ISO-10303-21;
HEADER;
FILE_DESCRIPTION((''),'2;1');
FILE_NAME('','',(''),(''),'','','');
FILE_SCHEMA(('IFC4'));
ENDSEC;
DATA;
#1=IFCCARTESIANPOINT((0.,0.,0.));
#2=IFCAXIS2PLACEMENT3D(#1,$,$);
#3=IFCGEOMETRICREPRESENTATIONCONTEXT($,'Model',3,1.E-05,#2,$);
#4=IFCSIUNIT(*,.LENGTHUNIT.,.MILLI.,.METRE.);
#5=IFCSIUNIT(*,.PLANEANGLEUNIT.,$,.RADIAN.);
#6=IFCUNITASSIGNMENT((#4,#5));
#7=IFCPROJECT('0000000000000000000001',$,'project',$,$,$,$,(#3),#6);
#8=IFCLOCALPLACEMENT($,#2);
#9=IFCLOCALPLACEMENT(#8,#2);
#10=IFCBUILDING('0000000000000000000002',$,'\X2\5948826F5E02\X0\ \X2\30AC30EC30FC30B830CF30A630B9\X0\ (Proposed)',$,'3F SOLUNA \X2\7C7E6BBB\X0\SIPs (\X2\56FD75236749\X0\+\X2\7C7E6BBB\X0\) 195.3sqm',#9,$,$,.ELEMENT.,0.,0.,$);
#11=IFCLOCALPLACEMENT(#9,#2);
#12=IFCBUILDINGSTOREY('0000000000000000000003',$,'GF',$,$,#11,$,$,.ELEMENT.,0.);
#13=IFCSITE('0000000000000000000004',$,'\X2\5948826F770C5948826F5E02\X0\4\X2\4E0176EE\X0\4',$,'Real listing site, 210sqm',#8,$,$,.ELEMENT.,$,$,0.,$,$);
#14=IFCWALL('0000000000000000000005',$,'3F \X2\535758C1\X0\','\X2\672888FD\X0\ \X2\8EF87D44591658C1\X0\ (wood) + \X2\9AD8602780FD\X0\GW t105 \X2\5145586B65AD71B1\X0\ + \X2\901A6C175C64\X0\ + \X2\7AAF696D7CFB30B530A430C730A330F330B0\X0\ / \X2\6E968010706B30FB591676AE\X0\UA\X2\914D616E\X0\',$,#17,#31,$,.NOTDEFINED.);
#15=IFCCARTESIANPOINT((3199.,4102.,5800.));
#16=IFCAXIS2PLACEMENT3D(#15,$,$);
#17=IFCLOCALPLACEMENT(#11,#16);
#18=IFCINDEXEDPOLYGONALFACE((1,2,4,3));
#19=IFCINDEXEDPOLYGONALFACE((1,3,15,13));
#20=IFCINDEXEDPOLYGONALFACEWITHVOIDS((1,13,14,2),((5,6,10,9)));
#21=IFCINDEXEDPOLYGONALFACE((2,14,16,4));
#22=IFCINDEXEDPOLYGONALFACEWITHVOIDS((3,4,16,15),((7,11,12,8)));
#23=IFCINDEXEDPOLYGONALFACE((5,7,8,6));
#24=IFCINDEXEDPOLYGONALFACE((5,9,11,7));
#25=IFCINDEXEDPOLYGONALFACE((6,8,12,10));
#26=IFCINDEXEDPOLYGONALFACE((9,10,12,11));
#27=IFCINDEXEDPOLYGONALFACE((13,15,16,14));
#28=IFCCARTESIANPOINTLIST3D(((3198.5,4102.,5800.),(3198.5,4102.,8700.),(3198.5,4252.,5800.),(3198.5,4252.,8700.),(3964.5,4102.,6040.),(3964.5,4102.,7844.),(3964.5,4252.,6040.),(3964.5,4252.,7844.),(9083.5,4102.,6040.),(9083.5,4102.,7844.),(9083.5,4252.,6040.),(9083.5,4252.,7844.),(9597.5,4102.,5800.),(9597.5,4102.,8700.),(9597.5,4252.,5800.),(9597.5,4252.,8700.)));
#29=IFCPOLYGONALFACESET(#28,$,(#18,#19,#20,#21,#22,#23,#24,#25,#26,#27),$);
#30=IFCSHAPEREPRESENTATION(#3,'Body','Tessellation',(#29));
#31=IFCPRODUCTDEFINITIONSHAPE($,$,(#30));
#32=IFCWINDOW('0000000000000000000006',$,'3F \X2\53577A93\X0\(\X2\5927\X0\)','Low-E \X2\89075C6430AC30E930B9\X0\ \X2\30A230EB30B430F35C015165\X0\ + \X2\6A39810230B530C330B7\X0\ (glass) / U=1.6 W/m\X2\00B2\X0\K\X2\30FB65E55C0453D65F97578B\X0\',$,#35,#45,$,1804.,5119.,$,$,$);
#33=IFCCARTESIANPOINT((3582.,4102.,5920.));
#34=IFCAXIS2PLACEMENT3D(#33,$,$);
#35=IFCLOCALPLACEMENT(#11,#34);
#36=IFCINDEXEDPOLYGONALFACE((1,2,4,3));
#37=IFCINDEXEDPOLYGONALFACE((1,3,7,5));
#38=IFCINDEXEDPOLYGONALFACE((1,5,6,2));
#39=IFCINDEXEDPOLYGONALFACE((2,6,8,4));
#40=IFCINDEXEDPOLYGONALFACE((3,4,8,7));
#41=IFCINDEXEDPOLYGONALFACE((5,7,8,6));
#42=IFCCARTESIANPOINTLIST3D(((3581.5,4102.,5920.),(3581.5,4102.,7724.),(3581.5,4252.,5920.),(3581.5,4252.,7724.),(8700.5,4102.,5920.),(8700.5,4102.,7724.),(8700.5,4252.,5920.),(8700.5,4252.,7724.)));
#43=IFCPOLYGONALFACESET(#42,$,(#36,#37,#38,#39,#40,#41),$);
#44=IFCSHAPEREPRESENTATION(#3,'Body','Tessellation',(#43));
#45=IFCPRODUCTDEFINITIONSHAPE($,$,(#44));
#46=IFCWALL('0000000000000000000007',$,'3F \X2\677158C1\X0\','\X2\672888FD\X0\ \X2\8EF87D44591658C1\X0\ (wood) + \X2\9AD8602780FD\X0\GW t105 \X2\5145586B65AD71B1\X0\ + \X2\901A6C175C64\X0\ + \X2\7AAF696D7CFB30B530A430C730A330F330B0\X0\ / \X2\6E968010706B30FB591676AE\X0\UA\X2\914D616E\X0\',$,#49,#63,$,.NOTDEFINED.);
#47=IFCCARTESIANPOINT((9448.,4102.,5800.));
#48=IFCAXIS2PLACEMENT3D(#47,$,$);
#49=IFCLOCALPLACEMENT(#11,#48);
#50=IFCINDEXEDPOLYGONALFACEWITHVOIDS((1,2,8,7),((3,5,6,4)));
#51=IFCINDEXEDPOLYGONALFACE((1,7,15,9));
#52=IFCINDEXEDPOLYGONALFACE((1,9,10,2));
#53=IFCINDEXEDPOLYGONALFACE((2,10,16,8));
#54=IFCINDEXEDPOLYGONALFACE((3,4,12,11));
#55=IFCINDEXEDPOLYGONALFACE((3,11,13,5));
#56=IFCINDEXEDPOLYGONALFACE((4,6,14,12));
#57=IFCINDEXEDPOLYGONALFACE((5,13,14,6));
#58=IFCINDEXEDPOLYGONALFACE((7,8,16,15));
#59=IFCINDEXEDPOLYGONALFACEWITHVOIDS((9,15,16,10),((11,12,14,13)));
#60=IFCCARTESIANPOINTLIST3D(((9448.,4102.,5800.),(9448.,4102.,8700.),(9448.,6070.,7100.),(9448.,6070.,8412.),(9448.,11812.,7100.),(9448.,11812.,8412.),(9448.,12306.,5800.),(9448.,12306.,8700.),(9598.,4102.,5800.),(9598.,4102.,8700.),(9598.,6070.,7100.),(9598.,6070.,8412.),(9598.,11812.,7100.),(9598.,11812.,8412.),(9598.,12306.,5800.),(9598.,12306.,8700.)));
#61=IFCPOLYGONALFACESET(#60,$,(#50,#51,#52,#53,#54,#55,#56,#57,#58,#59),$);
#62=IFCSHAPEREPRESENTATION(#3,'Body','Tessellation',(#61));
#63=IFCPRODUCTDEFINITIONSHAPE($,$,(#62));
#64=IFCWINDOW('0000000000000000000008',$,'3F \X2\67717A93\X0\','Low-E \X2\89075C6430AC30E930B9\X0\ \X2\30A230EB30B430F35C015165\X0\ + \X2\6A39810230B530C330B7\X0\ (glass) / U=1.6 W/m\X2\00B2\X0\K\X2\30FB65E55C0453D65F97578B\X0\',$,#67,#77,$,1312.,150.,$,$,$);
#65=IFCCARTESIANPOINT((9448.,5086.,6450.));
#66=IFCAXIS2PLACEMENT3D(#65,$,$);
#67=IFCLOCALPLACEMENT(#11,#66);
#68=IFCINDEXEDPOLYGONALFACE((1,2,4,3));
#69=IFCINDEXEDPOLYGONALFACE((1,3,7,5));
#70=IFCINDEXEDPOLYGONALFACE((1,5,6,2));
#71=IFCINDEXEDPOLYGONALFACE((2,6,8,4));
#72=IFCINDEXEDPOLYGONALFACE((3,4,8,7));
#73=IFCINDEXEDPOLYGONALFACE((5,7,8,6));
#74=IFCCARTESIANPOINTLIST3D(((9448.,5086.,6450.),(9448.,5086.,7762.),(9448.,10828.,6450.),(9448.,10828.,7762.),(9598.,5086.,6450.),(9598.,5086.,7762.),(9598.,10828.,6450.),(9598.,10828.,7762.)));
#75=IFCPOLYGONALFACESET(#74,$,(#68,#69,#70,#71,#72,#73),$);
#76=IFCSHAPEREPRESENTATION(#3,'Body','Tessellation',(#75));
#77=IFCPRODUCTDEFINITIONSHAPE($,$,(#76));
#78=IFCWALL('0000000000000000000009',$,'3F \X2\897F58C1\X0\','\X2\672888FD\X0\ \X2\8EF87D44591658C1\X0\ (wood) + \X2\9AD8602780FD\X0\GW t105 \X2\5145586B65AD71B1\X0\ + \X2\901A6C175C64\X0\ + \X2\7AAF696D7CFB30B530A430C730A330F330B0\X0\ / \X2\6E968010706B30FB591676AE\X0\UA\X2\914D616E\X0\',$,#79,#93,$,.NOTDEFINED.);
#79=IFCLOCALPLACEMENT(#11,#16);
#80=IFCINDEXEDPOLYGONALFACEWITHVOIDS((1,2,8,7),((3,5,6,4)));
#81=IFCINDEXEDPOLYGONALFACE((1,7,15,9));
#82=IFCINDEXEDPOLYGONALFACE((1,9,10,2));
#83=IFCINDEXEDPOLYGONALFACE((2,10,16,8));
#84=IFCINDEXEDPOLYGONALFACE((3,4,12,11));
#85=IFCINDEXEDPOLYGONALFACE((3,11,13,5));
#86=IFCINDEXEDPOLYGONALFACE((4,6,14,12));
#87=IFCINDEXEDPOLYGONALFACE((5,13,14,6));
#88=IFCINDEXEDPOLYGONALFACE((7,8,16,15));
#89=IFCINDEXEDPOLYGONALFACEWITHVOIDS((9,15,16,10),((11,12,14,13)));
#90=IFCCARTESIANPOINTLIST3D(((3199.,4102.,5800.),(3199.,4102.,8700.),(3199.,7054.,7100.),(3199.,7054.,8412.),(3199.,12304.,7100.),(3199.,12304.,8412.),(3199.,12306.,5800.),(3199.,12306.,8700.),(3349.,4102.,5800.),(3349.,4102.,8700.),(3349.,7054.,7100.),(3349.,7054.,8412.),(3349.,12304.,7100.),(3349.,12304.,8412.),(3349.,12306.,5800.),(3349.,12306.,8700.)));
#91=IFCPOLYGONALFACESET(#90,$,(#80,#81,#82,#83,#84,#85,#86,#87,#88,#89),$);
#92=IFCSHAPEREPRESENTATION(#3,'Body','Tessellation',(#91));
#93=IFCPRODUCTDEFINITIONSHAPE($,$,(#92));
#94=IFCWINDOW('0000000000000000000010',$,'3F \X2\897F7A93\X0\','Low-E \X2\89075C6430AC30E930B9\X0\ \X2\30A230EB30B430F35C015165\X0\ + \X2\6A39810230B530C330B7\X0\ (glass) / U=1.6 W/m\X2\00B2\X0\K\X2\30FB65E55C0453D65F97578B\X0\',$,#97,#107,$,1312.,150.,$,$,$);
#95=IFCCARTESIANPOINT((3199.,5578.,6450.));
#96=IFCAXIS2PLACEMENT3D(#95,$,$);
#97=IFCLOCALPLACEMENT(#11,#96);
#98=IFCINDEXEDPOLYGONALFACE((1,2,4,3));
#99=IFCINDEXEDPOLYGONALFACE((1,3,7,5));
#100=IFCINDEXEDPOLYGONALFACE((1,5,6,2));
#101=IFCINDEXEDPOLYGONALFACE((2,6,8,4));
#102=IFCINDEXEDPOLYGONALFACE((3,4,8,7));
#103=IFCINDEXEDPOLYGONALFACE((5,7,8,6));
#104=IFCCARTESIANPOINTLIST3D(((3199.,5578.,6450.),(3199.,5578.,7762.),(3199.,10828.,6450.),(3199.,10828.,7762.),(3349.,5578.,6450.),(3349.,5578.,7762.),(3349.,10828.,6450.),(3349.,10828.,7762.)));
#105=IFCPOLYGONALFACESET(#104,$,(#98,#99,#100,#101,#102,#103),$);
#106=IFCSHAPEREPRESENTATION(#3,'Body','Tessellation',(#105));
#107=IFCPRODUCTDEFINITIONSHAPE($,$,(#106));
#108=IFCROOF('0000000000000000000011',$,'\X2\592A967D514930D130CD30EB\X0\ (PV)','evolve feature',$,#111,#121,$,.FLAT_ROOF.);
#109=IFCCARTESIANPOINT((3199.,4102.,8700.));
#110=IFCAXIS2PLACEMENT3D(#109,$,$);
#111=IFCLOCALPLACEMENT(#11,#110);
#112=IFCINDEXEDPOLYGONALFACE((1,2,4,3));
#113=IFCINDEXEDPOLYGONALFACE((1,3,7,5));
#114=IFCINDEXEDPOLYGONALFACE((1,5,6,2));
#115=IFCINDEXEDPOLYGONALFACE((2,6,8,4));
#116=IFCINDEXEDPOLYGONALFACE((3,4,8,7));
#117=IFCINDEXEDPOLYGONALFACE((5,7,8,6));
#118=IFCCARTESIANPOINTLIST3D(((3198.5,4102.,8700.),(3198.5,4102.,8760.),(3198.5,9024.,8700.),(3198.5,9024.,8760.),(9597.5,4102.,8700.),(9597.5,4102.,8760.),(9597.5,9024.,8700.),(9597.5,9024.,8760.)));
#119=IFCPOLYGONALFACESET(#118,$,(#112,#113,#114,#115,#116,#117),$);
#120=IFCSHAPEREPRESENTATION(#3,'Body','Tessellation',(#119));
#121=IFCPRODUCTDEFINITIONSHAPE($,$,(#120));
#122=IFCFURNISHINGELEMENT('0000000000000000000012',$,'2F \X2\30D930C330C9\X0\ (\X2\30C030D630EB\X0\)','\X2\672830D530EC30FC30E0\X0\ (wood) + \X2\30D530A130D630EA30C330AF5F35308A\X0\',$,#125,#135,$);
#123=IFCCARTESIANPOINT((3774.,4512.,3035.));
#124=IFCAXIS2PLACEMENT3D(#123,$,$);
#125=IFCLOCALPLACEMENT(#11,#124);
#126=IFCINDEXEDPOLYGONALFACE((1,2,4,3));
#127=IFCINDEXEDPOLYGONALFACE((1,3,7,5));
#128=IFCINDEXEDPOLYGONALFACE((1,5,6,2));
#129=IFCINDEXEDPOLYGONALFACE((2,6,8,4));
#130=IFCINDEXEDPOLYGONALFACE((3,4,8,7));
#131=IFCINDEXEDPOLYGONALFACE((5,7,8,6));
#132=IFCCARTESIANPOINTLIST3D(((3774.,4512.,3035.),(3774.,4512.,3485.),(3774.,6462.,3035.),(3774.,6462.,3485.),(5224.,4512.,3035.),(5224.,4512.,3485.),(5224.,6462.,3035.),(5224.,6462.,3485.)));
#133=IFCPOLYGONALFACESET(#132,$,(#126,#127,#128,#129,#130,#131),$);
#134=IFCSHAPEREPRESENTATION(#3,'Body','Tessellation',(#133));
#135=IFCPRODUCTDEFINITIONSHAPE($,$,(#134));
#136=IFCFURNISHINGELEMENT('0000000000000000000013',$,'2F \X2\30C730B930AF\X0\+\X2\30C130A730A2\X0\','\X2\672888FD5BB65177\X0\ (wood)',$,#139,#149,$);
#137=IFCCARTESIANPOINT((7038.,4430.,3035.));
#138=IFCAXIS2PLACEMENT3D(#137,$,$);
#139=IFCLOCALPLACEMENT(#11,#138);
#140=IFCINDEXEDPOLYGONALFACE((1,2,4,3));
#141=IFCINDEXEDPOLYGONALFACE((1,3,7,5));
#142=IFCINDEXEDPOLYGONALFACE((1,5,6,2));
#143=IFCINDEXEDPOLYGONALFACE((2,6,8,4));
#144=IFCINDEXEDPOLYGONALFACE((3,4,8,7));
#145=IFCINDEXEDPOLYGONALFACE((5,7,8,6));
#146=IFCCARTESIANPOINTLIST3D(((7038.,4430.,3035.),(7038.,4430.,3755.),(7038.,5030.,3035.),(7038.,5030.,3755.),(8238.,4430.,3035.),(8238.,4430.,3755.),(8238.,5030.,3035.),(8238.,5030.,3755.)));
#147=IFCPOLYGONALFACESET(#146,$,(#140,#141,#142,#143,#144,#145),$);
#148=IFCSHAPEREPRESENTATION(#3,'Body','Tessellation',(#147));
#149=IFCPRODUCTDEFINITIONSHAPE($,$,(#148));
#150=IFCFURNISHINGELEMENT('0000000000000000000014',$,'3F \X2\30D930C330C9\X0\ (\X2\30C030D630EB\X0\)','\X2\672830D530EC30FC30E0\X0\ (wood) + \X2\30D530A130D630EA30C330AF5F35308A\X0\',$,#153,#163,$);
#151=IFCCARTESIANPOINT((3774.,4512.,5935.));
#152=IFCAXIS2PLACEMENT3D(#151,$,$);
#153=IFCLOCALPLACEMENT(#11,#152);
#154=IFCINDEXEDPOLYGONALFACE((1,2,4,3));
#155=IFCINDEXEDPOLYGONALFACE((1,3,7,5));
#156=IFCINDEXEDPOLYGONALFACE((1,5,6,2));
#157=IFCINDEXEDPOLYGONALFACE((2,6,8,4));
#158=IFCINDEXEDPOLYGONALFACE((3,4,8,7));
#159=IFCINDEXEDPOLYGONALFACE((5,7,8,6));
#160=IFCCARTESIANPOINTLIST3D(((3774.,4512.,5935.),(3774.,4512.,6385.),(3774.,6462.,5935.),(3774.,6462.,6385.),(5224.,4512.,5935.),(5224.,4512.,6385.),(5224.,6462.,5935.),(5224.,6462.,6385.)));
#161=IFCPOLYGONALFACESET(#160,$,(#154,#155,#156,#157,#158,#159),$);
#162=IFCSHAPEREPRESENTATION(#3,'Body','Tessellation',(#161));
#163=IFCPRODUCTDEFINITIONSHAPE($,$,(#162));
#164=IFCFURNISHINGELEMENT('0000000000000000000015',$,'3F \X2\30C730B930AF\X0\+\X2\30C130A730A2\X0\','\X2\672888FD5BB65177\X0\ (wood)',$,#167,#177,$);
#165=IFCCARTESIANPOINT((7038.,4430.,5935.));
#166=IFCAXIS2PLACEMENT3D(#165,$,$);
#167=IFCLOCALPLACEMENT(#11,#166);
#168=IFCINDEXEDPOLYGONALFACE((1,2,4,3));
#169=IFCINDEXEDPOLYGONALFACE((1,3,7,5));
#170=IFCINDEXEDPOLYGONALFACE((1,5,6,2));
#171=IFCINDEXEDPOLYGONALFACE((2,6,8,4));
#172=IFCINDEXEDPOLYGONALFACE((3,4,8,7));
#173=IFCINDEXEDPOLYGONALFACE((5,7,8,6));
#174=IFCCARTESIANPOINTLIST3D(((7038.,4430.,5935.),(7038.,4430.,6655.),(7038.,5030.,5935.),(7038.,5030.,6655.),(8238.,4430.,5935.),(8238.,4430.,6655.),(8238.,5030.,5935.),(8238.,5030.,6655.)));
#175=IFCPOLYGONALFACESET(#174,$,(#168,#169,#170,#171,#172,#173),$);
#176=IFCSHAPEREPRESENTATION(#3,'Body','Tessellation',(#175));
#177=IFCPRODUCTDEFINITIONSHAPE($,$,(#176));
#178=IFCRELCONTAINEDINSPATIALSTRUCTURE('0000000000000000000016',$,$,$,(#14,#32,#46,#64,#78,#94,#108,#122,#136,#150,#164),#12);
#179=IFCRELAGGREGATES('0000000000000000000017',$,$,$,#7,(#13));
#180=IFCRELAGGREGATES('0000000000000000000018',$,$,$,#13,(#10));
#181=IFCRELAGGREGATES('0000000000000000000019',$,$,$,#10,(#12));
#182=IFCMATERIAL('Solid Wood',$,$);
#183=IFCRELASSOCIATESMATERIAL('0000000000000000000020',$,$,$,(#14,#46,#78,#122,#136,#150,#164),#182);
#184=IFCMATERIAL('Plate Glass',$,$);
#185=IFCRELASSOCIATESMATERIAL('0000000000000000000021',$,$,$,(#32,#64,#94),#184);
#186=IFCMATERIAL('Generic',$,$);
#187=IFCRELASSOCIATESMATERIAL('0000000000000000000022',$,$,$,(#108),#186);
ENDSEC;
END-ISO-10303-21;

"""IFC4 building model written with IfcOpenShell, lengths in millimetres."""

from ifc_helpers import new_model, si_unit, frame, frame_2d, origin, place, context, project, spatial, rectangle, extrude, material, element, fill, save


model = new_model("IFC4")

# Units and contexts
model_context = context("Model", 3, precision=1e-05, world=origin())
ifc_project = project(units=[si_unit("LENGTHUNIT", "METRE", prefix="MILLI"), si_unit("PLANEANGLEUNIT", "RADIAN")], contexts=[model_context])

# Site, building, storey
site_placement = place(None, origin())
site = spatial("IfcSite", under=ifc_project, at=site_placement, Name="奈良県奈良市4丁目4", ObjectType="Real listing site, 210sqm", CompositionType="ELEMENT", RefElevation=0.0)
building_placement = place(site_placement, origin())
building = spatial("IfcBuilding", under=site, at=building_placement, Name="奈良市 ガレージハウス (Proposed)", ObjectType="3F SOLUNA 籾殻SIPs (国産杉+籾殻) 195.3sqm", CompositionType="ELEMENT", ElevationOfRefHeight=0.0, ElevationOfTerrain=0.0)
storey_placement = place(building_placement, origin())
storey = spatial("IfcBuildingStorey", under=building, at=storey_placement, Name="GF", CompositionType="ELEMENT", Elevation=0.0)

# Shared definitions
ifc_material_1 = material(Name="Solid Wood")

# Walls, openings, windows
wall_1_placement = place(storey_placement, frame((3199.0, 4102.0, 5800.0)))
wall_1 = element("IfcWall", 1, at=wall_1_placement, inside=storey, material=ifc_material_1, Name="3F 南壁", Description="木製 軸組外壁 (wood) + 高性能GW t105 充填断熱 + 通気層 + 窯業系サイディング / 準耐火・外皮UA配慮", PredefinedType="NOTDEFINED", context=model_context, shape_type="SweptSolid", body=[
    extrude(rectangle(XDim=6399.0, YDim=150.0, at=frame_2d((3199.0, 75.0))), frame((3199.0, 4102.0, 5800.0)), (0.0, 0.0, 1.0), 2900.0),
])
opening_1_placement = place(storey_placement, frame((3582.0, 4102.0, 5920.0)))
opening_1 = element("IfcOpeningElement", 2, at=opening_1_placement, cuts=wall_1, PredefinedType="NOTDEFINED", context=model_context, shape_type="SweptSolid", body=[
    extrude(rectangle(XDim=5119.0, YDim=150.0, at=frame_2d((2559.0, 75.0))), frame((3582.0, 4102.0, 5920.0)), (0.0, 0.0, 1.0), 1804.0),
])
ifc_material_2 = material(Name="Plate Glass")
window_1_placement = place(storey_placement, frame((3582.0, 4102.0, 5920.0)))
window_1 = element("IfcWindow", 3, at=window_1_placement, inside=storey, material=ifc_material_2, Name="3F 南窓(大)", Description="Low-E 複層ガラス アルゴン封入 + 樹脂サッシ (glass) / U=1.6 W/m²K・日射取得型", OverallHeight=1804.0, OverallWidth=5119.0, context=model_context, shape_type="SweptSolid", body=[
    extrude(rectangle(XDim=5119.0, YDim=150.0, at=frame_2d((2559.0, 75.0))), frame((3582.0, 4102.0, 5920.0)), (0.0, 0.0, 1.0), 1804.0),
])
fill(opening_1, window_1)
wall_2_placement = place(storey_placement, frame((9448.0, 4102.0, 5800.0)))
wall_2 = element("IfcWall", 4, at=wall_2_placement, inside=storey, material=ifc_material_1, Name="3F 東壁", Description="木製 軸組外壁 (wood) + 高性能GW t105 充填断熱 + 通気層 + 窯業系サイディング / 準耐火・外皮UA配慮", PredefinedType="NOTDEFINED", context=model_context, shape_type="SweptSolid", body=[
    extrude(rectangle(XDim=150.0, YDim=8204.0, at=frame_2d((75.0, 4102.0))), frame((9448.0, 4102.0, 5800.0)), (0.0, 0.0, 1.0), 2900.0),
])
opening_2_placement = place(storey_placement, frame((9448.0, 5086.0, 6450.0)))
opening_2 = element("IfcOpeningElement", 5, at=opening_2_placement, cuts=wall_2, PredefinedType="NOTDEFINED", context=model_context, shape_type="SweptSolid", body=[
    extrude(rectangle(XDim=150.0, YDim=5742.0, at=frame_2d((75.0, 2871.0))), frame((9448.0, 5086.0, 6450.0)), (0.0, 0.0, 1.0), 1312.0),
])
window_2_placement = place(storey_placement, frame((9448.0, 5086.0, 6450.0)))
window_2 = element("IfcWindow", 6, at=window_2_placement, inside=storey, material=ifc_material_2, Name="3F 東窓", Description="Low-E 複層ガラス アルゴン封入 + 樹脂サッシ (glass) / U=1.6 W/m²K・日射取得型", OverallHeight=1312.0, OverallWidth=150.0, context=model_context, shape_type="SweptSolid", body=[
    extrude(rectangle(XDim=150.0, YDim=5742.0, at=frame_2d((75.0, 2871.0))), frame((9448.0, 5086.0, 6450.0)), (0.0, 0.0, 1.0), 1312.0),
])
fill(opening_2, window_2)
wall_3_placement = place(storey_placement, frame((3199.0, 4102.0, 5800.0)))
wall_3 = element("IfcWall", 7, at=wall_3_placement, inside=storey, material=ifc_material_1, Name="3F 西壁", Description="木製 軸組外壁 (wood) + 高性能GW t105 充填断熱 + 通気層 + 窯業系サイディング / 準耐火・外皮UA配慮", PredefinedType="NOTDEFINED", context=model_context, shape_type="SweptSolid", body=[
    extrude(rectangle(XDim=150.0, YDim=8204.0, at=frame_2d((75.0, 4102.0))), frame((3199.0, 4102.0, 5800.0)), (0.0, 0.0, 1.0), 2900.0),
])
opening_3_placement = place(storey_placement, frame((3199.0, 5578.0, 6450.0)))
opening_3 = element("IfcOpeningElement", 8, at=opening_3_placement, cuts=wall_3, PredefinedType="NOTDEFINED", context=model_context, shape_type="SweptSolid", body=[
    extrude(rectangle(XDim=150.0, YDim=5250.0, at=frame_2d((75.0, 2625.0))), frame((3199.0, 5578.0, 6450.0)), (0.0, 0.0, 1.0), 1312.0),
])
window_3_placement = place(storey_placement, frame((3199.0, 5578.0, 6450.0)))
window_3 = element("IfcWindow", 9, at=window_3_placement, inside=storey, material=ifc_material_2, Name="3F 西窓", Description="Low-E 複層ガラス アルゴン封入 + 樹脂サッシ (glass) / U=1.6 W/m²K・日射取得型", OverallHeight=1312.0, OverallWidth=150.0, context=model_context, shape_type="SweptSolid", body=[
    extrude(rectangle(XDim=150.0, YDim=5250.0, at=frame_2d((75.0, 2625.0))), frame((3199.0, 5578.0, 6450.0)), (0.0, 0.0, 1.0), 1312.0),
])
fill(opening_3, window_3)

# Roof
ifc_material_3 = material(Name="Generic")
roof_1_placement = place(storey_placement, frame((3199.0, 4102.0, 8700.0)))
element("IfcRoof", 10, at=roof_1_placement, inside=storey, material=ifc_material_3, Name="太陽光パネル (PV)", Description="evolve feature", PredefinedType="FLAT_ROOF", context=model_context, shape_type="SweptSolid", body=[
    extrude(rectangle(XDim=6399.0, YDim=4922.0, at=frame_2d((3199.0, 2461.0))), frame((3199.0, 4102.0, 8700.0)), (0.0, 0.0, 1.0), 60.0),
])

# Furnishing elements
furnishing_1_placement = place(storey_placement, frame((3774.0, 4512.0, 3035.0)))
element("IfcFurnishingElement", 11, at=furnishing_1_placement, inside=storey, material=ifc_material_1, Name="2F ベッド (ダブル)", Description="木フレーム (wood) + ファブリック張り", context=model_context, shape_type="SweptSolid", body=[
    extrude(rectangle(XDim=1450.0, YDim=1950.0, at=frame_2d((725.0, 975.0))), frame((3774.0, 4512.0, 3035.0)), (0.0, 0.0, 1.0), 450.0),
])
furnishing_2_placement = place(storey_placement, frame((7038.0, 4430.0, 3035.0)))
element("IfcFurnishingElement", 12, at=furnishing_2_placement, inside=storey, material=ifc_material_1, Name="2F デスク+チェア", Description="木製家具 (wood)", context=model_context, shape_type="SweptSolid", body=[
    extrude(rectangle(XDim=1200.0, YDim=600.0, at=frame_2d((600.0, 300.0))), frame((7038.0, 4430.0, 3035.0)), (0.0, 0.0, 1.0), 720.0),
])
furnishing_3_placement = place(storey_placement, frame((3774.0, 4512.0, 5935.0)))
element("IfcFurnishingElement", 13, at=furnishing_3_placement, inside=storey, material=ifc_material_1, Name="3F ベッド (ダブル)", Description="木フレーム (wood) + ファブリック張り", context=model_context, shape_type="SweptSolid", body=[
    extrude(rectangle(XDim=1450.0, YDim=1950.0, at=frame_2d((725.0, 975.0))), frame((3774.0, 4512.0, 5935.0)), (0.0, 0.0, 1.0), 450.0),
])
furnishing_4_placement = place(storey_placement, frame((7038.0, 4430.0, 5935.0)))
element("IfcFurnishingElement", 14, at=furnishing_4_placement, inside=storey, material=ifc_material_1, Name="3F デスク+チェア", Description="木製家具 (wood)", context=model_context, shape_type="SweptSolid", body=[
    extrude(rectangle(XDim=1200.0, YDim=600.0, at=frame_2d((600.0, 300.0))), frame((7038.0, 4430.0, 5935.0)), (0.0, 0.0, 1.0), 720.0),
])

save(model, "model.ifc")
